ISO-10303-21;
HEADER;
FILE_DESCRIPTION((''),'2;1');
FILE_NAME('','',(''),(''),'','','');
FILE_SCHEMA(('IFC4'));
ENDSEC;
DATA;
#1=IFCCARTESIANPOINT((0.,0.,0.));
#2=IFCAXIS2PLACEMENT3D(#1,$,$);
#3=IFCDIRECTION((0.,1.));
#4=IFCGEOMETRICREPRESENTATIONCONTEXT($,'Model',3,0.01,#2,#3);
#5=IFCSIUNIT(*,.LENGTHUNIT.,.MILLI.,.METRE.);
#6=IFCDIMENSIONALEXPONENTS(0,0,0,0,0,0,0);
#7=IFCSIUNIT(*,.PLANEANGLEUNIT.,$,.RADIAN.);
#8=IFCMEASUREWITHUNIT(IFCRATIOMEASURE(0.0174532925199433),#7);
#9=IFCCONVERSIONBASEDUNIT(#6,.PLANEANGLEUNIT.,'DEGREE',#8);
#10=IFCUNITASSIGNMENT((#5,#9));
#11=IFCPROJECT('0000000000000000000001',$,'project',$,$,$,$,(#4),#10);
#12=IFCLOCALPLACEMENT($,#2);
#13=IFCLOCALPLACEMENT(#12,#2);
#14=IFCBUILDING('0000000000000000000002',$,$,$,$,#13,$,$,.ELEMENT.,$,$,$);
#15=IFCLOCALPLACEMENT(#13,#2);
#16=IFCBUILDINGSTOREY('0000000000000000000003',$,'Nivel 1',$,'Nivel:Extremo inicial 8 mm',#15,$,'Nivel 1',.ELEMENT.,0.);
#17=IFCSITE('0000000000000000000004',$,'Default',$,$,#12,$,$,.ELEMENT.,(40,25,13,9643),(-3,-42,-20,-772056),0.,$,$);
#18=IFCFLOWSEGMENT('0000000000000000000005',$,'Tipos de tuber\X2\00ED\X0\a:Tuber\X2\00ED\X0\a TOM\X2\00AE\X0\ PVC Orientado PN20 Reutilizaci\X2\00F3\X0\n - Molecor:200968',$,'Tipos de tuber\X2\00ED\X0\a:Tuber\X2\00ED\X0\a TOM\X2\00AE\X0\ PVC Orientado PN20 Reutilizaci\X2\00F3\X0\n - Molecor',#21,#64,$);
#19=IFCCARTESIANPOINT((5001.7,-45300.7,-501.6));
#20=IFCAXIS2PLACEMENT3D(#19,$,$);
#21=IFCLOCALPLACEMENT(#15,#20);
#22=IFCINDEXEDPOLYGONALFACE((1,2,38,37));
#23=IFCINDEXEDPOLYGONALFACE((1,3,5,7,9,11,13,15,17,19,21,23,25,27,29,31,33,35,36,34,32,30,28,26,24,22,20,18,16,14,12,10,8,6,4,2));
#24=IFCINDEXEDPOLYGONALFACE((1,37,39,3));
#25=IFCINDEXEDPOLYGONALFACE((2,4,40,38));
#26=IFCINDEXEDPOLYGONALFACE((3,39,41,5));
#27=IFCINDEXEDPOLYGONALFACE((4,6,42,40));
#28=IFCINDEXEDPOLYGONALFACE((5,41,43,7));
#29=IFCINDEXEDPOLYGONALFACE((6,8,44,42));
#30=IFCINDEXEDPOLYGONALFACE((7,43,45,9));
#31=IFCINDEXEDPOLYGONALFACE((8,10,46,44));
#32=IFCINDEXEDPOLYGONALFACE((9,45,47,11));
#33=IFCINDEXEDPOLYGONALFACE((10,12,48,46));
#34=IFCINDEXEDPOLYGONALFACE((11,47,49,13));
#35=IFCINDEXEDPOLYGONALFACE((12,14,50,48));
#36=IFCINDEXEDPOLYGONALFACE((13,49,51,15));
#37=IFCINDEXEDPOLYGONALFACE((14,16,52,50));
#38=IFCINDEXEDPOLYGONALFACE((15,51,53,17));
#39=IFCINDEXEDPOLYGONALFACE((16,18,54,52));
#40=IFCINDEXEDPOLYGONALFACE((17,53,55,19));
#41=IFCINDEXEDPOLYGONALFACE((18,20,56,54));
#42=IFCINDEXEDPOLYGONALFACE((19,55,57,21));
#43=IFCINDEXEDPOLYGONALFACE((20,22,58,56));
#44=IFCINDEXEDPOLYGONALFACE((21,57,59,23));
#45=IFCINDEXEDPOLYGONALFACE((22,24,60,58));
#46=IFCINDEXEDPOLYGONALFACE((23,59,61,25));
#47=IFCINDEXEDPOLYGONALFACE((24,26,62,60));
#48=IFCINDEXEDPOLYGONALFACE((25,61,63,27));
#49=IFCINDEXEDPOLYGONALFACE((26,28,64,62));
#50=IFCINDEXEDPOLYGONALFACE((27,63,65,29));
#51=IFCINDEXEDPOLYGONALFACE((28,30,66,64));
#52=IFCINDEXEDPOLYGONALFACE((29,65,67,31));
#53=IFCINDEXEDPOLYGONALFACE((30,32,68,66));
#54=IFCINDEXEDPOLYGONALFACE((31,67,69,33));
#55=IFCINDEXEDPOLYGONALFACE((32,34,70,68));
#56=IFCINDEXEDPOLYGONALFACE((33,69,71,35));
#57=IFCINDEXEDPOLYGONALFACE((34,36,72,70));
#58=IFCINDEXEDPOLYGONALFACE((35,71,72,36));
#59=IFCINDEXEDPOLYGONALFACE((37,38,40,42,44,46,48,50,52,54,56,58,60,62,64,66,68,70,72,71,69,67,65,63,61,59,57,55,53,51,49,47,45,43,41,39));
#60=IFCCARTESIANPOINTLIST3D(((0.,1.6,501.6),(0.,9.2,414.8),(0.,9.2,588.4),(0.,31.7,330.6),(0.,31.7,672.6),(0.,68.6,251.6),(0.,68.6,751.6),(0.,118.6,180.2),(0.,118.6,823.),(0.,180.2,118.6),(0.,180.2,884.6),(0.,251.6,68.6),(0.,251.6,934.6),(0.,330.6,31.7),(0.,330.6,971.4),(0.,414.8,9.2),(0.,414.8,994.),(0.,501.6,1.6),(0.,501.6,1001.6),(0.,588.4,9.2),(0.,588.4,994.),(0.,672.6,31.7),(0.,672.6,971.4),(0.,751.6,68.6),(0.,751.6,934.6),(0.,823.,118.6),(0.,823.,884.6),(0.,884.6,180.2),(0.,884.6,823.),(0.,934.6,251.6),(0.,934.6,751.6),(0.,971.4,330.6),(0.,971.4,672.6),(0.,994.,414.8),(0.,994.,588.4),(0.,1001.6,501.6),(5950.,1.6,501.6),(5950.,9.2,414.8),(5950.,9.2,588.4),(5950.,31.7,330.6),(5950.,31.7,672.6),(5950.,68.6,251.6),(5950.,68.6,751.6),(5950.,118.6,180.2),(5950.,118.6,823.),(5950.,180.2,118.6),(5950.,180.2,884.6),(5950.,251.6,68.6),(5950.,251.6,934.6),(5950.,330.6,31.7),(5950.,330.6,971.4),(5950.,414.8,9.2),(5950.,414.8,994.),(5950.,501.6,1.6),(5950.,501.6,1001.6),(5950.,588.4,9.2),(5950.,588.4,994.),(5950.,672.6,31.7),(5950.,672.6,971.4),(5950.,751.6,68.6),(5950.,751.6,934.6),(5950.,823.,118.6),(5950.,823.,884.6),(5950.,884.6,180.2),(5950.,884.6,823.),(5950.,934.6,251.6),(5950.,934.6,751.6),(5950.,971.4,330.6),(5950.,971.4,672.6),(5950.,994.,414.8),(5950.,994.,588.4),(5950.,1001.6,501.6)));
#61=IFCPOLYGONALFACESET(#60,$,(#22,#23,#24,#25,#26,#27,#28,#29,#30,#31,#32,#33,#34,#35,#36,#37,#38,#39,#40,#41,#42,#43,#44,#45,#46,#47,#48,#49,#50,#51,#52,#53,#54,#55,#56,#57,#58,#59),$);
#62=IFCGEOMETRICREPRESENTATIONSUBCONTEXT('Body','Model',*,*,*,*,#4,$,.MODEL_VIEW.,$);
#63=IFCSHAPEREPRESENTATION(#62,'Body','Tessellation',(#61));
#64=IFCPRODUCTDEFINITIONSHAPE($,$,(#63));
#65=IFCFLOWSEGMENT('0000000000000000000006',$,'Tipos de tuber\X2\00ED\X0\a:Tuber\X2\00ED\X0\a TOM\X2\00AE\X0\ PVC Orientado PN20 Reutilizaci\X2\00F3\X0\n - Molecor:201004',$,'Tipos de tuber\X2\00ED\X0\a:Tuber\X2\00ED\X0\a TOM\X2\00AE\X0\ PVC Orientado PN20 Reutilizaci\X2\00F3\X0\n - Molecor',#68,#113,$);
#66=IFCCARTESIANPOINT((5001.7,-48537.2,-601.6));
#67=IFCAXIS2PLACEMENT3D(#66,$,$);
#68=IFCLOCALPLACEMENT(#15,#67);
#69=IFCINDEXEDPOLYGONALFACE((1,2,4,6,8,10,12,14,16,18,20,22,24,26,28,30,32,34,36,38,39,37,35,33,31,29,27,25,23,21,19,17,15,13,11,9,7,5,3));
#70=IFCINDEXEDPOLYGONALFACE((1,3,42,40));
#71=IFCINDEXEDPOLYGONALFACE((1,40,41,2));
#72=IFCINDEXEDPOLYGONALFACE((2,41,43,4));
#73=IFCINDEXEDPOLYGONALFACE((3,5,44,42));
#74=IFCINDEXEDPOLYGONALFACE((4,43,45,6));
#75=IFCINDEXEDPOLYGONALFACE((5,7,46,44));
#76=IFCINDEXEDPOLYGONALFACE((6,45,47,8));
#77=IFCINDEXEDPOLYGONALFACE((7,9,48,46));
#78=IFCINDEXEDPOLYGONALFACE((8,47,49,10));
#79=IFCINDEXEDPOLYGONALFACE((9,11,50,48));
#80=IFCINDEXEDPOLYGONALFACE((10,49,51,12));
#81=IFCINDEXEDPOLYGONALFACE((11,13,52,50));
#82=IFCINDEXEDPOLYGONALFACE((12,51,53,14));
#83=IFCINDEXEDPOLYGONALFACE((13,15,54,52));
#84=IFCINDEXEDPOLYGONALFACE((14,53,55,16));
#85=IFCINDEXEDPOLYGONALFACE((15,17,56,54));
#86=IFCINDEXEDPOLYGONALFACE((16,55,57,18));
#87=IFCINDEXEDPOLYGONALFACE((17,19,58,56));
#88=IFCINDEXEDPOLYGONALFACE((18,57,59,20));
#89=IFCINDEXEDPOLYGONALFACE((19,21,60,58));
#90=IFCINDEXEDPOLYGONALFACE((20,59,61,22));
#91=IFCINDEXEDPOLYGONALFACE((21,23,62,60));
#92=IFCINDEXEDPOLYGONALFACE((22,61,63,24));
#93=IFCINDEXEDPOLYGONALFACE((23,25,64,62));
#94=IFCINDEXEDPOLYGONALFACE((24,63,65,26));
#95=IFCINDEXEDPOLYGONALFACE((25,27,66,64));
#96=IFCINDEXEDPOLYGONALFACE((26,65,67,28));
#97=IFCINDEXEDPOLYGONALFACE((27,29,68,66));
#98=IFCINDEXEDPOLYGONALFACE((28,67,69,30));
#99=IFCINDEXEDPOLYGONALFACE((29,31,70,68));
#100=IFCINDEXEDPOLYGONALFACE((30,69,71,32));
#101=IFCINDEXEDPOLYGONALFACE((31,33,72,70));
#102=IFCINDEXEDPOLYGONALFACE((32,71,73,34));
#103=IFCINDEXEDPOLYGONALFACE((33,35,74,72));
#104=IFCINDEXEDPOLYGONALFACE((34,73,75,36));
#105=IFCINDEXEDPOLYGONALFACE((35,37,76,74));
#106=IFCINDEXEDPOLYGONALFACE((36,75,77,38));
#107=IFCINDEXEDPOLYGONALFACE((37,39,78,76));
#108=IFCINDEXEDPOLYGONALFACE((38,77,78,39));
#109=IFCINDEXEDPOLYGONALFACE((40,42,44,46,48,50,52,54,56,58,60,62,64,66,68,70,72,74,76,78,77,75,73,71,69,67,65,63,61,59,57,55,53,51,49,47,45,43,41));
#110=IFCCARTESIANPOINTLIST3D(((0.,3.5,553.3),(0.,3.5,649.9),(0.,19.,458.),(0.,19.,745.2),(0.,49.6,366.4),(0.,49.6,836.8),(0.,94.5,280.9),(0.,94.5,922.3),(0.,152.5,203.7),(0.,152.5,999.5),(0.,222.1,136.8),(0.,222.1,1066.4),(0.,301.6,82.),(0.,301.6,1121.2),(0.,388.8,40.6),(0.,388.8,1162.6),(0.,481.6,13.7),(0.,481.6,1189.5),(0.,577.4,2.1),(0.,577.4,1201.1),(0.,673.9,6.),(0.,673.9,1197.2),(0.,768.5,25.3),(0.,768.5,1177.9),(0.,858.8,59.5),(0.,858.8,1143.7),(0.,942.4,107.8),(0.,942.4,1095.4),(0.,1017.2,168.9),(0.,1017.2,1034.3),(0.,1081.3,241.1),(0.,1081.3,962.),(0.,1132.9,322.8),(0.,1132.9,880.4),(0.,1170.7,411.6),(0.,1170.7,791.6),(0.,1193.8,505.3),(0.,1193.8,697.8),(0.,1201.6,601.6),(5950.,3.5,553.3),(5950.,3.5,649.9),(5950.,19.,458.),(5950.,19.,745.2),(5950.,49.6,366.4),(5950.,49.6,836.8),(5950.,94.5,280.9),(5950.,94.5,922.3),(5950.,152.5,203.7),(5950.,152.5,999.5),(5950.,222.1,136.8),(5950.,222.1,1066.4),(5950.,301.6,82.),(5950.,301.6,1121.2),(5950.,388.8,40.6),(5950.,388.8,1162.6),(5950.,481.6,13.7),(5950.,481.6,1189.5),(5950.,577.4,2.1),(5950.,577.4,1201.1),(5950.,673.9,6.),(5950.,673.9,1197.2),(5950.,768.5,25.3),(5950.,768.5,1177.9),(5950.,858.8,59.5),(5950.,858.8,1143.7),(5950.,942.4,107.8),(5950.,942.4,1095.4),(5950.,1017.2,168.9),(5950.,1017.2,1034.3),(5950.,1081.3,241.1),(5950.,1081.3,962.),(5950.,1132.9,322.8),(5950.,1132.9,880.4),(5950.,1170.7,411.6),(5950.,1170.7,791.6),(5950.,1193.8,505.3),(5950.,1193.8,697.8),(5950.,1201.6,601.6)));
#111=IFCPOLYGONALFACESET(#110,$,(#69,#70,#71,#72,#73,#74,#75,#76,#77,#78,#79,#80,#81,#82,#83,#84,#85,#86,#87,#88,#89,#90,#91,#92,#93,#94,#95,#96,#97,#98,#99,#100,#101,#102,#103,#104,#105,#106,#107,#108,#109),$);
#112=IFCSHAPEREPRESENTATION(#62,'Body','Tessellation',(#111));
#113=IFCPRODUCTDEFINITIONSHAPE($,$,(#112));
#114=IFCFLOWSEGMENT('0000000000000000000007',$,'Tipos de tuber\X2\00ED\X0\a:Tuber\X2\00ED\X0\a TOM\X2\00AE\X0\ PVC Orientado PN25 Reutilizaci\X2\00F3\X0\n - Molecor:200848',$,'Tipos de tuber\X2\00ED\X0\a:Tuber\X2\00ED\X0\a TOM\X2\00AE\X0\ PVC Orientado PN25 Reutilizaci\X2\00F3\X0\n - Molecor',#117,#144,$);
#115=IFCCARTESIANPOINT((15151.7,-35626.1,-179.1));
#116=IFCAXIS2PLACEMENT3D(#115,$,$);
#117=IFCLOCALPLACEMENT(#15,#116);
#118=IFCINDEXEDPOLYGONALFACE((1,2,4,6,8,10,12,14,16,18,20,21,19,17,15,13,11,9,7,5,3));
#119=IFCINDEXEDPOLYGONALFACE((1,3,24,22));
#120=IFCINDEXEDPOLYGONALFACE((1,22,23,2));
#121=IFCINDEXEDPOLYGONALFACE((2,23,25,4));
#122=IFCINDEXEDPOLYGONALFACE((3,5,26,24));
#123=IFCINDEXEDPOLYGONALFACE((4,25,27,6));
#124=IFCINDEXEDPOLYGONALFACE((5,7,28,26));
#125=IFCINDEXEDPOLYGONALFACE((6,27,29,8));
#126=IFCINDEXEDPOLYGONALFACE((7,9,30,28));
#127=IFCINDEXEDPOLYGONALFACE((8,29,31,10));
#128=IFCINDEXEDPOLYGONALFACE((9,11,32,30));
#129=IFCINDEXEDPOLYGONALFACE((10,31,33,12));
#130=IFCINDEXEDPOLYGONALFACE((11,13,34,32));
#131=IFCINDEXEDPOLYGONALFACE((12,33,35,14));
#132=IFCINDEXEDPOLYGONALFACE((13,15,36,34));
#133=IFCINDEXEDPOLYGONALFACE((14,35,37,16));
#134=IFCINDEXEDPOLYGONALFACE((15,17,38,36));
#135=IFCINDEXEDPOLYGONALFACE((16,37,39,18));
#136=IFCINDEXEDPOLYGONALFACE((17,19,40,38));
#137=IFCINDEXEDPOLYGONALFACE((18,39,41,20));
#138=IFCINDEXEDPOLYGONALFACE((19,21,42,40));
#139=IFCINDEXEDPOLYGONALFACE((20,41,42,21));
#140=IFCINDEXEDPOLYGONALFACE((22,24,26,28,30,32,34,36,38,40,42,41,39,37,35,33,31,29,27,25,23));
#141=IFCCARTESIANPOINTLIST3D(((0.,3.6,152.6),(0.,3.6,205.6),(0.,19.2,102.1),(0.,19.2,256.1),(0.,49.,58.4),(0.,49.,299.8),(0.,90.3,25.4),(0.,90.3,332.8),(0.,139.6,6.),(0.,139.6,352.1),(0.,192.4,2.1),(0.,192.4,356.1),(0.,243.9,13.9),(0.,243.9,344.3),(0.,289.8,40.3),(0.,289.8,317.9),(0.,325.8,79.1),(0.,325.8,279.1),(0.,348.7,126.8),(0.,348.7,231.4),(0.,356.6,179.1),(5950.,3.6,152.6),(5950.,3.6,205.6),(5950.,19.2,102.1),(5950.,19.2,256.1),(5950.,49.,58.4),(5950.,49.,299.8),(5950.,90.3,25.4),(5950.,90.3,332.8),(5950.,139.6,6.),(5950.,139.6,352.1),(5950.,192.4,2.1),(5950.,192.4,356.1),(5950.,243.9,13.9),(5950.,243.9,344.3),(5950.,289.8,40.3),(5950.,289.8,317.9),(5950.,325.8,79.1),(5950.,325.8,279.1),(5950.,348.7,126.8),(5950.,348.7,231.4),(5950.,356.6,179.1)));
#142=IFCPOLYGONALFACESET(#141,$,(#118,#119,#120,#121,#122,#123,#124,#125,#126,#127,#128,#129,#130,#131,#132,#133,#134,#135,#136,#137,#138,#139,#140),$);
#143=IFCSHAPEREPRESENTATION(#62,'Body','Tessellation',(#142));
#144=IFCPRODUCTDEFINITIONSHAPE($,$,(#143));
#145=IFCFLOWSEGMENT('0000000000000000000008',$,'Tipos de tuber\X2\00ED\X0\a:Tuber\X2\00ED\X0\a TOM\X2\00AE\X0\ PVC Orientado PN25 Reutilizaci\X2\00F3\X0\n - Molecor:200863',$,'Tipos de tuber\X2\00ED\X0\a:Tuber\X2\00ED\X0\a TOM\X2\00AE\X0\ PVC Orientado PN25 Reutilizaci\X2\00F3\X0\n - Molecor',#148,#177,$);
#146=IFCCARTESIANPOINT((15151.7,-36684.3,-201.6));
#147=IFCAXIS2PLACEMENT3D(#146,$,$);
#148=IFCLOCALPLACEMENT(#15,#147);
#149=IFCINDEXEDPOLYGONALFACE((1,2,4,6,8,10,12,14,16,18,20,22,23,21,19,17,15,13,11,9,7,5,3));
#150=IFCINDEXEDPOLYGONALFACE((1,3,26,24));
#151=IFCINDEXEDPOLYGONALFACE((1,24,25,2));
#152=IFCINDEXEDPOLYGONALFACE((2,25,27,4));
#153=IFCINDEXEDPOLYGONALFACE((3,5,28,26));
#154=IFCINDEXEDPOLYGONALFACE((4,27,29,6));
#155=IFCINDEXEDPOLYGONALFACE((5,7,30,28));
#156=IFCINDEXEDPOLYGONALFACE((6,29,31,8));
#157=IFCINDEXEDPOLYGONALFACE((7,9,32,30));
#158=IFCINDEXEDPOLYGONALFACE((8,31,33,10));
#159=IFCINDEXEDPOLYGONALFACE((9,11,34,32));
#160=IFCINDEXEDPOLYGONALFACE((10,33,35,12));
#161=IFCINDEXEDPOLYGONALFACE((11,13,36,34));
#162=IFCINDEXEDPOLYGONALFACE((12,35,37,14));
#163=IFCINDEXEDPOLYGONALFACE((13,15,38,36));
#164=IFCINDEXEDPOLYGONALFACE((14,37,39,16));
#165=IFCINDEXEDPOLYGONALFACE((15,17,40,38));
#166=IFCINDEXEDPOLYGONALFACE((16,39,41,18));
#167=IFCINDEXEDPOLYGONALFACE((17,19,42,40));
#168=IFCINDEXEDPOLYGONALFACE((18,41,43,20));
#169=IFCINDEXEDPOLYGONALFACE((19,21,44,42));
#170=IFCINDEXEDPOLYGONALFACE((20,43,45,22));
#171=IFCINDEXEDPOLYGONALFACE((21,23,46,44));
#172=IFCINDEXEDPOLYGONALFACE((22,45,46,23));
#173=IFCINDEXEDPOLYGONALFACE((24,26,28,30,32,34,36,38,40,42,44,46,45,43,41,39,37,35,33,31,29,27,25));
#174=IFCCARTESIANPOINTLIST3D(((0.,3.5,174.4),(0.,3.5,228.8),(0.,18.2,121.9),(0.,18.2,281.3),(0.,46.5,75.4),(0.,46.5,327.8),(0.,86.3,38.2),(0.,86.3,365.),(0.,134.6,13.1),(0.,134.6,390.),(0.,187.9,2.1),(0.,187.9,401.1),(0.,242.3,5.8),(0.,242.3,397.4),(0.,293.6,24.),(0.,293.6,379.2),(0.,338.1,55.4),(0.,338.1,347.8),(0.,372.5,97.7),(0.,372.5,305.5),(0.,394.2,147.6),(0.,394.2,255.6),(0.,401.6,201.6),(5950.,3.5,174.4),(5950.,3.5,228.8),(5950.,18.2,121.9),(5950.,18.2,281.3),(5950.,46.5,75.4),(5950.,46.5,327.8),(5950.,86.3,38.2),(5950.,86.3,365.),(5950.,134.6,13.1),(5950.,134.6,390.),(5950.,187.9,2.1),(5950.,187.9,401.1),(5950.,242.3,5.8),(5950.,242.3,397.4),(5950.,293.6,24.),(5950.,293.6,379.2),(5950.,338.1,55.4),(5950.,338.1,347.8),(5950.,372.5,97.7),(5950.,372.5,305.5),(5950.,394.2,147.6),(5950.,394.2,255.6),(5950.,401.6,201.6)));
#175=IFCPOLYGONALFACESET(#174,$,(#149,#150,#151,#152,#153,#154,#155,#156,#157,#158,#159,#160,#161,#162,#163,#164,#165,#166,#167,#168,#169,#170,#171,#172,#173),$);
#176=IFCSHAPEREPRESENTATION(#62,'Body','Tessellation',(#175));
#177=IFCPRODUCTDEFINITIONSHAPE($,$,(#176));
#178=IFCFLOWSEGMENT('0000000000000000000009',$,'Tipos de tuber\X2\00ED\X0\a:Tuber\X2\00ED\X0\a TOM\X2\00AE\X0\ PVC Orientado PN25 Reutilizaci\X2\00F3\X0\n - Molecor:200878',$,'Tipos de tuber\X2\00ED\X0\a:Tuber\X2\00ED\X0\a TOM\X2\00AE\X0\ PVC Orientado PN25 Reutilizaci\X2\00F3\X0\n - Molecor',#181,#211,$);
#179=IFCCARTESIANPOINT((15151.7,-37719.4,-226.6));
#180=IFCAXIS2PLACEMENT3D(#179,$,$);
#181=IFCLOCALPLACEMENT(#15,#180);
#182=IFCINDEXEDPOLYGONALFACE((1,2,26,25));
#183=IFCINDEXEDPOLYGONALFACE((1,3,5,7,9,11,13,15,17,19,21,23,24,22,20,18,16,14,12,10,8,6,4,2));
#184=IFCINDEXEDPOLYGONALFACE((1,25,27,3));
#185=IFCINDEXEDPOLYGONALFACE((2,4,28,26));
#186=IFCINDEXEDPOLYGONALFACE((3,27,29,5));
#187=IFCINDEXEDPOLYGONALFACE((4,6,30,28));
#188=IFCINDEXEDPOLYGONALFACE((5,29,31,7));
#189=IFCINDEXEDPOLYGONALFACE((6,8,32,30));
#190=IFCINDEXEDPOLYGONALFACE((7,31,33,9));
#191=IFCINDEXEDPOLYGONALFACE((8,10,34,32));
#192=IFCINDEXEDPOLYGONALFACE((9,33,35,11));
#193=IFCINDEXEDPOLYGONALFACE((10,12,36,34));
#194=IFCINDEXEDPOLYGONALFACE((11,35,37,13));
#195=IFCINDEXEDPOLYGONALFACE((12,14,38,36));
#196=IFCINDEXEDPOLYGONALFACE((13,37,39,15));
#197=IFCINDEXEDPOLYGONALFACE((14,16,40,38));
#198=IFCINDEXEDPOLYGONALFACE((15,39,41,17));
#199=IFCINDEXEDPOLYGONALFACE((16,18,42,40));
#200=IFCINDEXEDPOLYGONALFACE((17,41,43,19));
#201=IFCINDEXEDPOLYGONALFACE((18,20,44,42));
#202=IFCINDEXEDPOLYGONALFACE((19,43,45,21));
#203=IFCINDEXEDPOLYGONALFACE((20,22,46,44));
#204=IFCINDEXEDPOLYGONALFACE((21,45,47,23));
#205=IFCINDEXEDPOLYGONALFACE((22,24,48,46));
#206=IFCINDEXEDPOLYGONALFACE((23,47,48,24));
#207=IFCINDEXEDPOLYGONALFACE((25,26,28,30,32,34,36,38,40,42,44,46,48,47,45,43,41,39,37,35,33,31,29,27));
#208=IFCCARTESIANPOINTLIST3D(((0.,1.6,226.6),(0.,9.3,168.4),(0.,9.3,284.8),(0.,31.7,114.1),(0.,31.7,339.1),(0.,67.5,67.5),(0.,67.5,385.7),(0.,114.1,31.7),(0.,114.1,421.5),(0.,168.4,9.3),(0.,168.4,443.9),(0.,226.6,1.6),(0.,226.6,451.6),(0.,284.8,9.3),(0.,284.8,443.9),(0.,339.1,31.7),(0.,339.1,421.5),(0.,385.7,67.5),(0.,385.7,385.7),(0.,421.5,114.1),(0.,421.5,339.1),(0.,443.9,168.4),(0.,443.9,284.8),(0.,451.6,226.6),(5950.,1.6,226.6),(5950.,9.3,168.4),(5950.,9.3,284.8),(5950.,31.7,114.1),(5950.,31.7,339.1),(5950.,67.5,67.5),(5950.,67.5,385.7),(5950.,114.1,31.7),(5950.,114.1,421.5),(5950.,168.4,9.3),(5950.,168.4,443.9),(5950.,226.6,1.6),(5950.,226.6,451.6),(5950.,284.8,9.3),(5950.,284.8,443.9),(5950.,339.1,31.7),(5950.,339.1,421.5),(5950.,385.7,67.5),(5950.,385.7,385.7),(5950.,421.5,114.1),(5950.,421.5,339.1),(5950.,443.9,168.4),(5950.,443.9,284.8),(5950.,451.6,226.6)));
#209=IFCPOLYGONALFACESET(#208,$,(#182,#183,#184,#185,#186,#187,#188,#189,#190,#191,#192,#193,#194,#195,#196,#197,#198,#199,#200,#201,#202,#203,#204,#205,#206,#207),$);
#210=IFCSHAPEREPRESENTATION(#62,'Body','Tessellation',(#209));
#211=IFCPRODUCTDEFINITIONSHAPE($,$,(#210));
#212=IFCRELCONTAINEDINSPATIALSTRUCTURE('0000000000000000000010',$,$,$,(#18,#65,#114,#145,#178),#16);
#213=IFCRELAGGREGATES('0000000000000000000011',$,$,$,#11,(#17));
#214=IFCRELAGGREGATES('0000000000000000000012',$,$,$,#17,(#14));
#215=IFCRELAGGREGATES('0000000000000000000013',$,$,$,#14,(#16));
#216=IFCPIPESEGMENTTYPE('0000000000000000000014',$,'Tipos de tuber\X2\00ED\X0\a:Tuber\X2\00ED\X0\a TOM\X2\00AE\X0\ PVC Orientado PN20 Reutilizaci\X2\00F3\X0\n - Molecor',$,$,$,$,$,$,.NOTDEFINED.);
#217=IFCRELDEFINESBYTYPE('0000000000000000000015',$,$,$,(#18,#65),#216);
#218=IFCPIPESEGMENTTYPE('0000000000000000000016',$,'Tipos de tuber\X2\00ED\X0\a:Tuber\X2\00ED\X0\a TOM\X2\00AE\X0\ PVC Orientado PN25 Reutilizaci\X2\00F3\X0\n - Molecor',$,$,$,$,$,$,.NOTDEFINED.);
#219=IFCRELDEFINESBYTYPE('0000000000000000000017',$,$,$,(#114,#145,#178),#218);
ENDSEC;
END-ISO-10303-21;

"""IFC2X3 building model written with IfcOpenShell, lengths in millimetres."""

from ifc_helpers import new_model, entity, si_unit, converted_unit, direction, frame, frame_2d, origin, place, context, subcontext, project, spatial, circle, extrude, type_object, element, save


model = new_model("IFC2X3")

# Units and contexts
model_context = context("Model", 3, precision=0.01, world=origin(), true_north=direction((0.0, 1.0)))
body_context = subcontext(model_context, "Body", "Model", "MODEL_VIEW")
ifc_project = project(units=[si_unit("LENGTHUNIT", "METRE", prefix="MILLI"), converted_unit("PLANEANGLEUNIT", "DEGREE", entity("IfcRatioMeasure", 0.0174532925199433), si_unit("PLANEANGLEUNIT", "RADIAN"), dimensions=[0, 0, 0, 0, 0, 0, 0])], contexts=[model_context])

# Site, building, storey
site_placement = place(None, origin())
site = spatial("IfcSite", under=ifc_project, at=site_placement, Name="Default", CompositionType="ELEMENT", RefLatitude=(40, 25, 13, 9643), RefLongitude=(-3, -42, -20, -772056), RefElevation=0.0)
building_placement = place(site_placement, origin())
building = spatial("IfcBuilding", under=site, at=building_placement, CompositionType="ELEMENT")
storey_placement = place(building_placement, origin())
storey = spatial("IfcBuildingStorey", under=building, at=storey_placement, Name="Nivel 1", ObjectType="Nivel:Extremo inicial 8 mm", LongName="Nivel 1", CompositionType="ELEMENT", Elevation=0.0)

# Flow segments
pipe_segment_type_1 = type_object("IfcPipeSegmentType", Name="Tipos de tubería:Tubería TOM® PVC Orientado PN20 Reutilización - Molecor", PredefinedType="NOTDEFINED")
flow_segment_1_placement = place(storey_placement, frame((5001.7, -45300.7, -501.6)))
element("IfcFlowSegment", 1, at=flow_segment_1_placement, inside=storey, type_object=pipe_segment_type_1, Name="Tipos de tubería:Tubería TOM® PVC Orientado PN20 Reutilización - Molecor:200968", ObjectType="Tipos de tubería:Tubería TOM® PVC Orientado PN20 Reutilización - Molecor", context=body_context, shape_type="SweptSolid", body=[
    extrude(circle(Radius=500.0, at=frame_2d((0.0, 0.0), x_axis=(1.0, 0.0))), frame((0.0, 501.6, 501.6), z_axis=(1.0, 0.0, 0.0), x_axis=(0.0, 1.0, 0.0)), (0.0, 0.0, 1.0), 5950.0),
])
flow_segment_2_placement = place(storey_placement, frame((5001.7, -48537.2, -601.6)))
element("IfcFlowSegment", 2, at=flow_segment_2_placement, inside=storey, type_object=pipe_segment_type_1, Name="Tipos de tubería:Tubería TOM® PVC Orientado PN20 Reutilización - Molecor:201004", ObjectType="Tipos de tubería:Tubería TOM® PVC Orientado PN20 Reutilización - Molecor", context=body_context, shape_type="SweptSolid", body=[
    extrude(circle(Radius=600.0, at=frame_2d((0.0, 0.0), x_axis=(1.0, 0.0))), frame((0.0, 601.6, 601.6), z_axis=(1.0, 0.0, 0.0), x_axis=(0.0, 1.0, 0.0)), (0.0, 0.0, 1.0), 5950.0),
])
pipe_segment_type_2 = type_object("IfcPipeSegmentType", Name="Tipos de tubería:Tubería TOM® PVC Orientado PN25 Reutilización - Molecor", PredefinedType="NOTDEFINED")
flow_segment_3_placement = place(storey_placement, frame((15151.7, -35626.1, -179.1)))
element("IfcFlowSegment", 3, at=flow_segment_3_placement, inside=storey, type_object=pipe_segment_type_2, Name="Tipos de tubería:Tubería TOM® PVC Orientado PN25 Reutilización - Molecor:200848", ObjectType="Tipos de tubería:Tubería TOM® PVC Orientado PN25 Reutilización - Molecor", context=body_context, shape_type="SweptSolid", body=[
    extrude(circle(Radius=177.5, at=frame_2d((0.0, 0.0), x_axis=(1.0, 0.0))), frame((0.0, 179.1, 179.1), z_axis=(1.0, 0.0, 0.0), x_axis=(0.0, 1.0, 0.0)), (0.0, 0.0, 1.0), 5950.0),
])
flow_segment_4_placement = place(storey_placement, frame((15151.7, -36684.3, -201.6)))
element("IfcFlowSegment", 4, at=flow_segment_4_placement, inside=storey, type_object=pipe_segment_type_2, Name="Tipos de tubería:Tubería TOM® PVC Orientado PN25 Reutilización - Molecor:200863", ObjectType="Tipos de tubería:Tubería TOM® PVC Orientado PN25 Reutilización - Molecor", context=body_context, shape_type="SweptSolid", body=[
    extrude(circle(Radius=200.0, at=frame_2d((0.0, 0.0), x_axis=(1.0, 0.0))), frame((0.0, 201.6, 201.6), z_axis=(1.0, 0.0, 0.0), x_axis=(0.0, 1.0, 0.0)), (0.0, 0.0, 1.0), 5950.0),
])
flow_segment_5_placement = place(storey_placement, frame((15151.7, -37719.4, -226.6)))
element("IfcFlowSegment", 5, at=flow_segment_5_placement, inside=storey, type_object=pipe_segment_type_2, Name="Tipos de tubería:Tubería TOM® PVC Orientado PN25 Reutilización - Molecor:200878", ObjectType="Tipos de tubería:Tubería TOM® PVC Orientado PN25 Reutilización - Molecor", context=body_context, shape_type="SweptSolid", body=[
    extrude(circle(Radius=225.0, at=frame_2d((0.0, 0.0), x_axis=(1.0, 0.0))), frame((0.0, 226.6, 226.6), z_axis=(1.0, 0.0, 0.0), x_axis=(0.0, 1.0, 0.0)), (0.0, 0.0, 1.0), 5950.0),
])

save(model, "model.ifc")
